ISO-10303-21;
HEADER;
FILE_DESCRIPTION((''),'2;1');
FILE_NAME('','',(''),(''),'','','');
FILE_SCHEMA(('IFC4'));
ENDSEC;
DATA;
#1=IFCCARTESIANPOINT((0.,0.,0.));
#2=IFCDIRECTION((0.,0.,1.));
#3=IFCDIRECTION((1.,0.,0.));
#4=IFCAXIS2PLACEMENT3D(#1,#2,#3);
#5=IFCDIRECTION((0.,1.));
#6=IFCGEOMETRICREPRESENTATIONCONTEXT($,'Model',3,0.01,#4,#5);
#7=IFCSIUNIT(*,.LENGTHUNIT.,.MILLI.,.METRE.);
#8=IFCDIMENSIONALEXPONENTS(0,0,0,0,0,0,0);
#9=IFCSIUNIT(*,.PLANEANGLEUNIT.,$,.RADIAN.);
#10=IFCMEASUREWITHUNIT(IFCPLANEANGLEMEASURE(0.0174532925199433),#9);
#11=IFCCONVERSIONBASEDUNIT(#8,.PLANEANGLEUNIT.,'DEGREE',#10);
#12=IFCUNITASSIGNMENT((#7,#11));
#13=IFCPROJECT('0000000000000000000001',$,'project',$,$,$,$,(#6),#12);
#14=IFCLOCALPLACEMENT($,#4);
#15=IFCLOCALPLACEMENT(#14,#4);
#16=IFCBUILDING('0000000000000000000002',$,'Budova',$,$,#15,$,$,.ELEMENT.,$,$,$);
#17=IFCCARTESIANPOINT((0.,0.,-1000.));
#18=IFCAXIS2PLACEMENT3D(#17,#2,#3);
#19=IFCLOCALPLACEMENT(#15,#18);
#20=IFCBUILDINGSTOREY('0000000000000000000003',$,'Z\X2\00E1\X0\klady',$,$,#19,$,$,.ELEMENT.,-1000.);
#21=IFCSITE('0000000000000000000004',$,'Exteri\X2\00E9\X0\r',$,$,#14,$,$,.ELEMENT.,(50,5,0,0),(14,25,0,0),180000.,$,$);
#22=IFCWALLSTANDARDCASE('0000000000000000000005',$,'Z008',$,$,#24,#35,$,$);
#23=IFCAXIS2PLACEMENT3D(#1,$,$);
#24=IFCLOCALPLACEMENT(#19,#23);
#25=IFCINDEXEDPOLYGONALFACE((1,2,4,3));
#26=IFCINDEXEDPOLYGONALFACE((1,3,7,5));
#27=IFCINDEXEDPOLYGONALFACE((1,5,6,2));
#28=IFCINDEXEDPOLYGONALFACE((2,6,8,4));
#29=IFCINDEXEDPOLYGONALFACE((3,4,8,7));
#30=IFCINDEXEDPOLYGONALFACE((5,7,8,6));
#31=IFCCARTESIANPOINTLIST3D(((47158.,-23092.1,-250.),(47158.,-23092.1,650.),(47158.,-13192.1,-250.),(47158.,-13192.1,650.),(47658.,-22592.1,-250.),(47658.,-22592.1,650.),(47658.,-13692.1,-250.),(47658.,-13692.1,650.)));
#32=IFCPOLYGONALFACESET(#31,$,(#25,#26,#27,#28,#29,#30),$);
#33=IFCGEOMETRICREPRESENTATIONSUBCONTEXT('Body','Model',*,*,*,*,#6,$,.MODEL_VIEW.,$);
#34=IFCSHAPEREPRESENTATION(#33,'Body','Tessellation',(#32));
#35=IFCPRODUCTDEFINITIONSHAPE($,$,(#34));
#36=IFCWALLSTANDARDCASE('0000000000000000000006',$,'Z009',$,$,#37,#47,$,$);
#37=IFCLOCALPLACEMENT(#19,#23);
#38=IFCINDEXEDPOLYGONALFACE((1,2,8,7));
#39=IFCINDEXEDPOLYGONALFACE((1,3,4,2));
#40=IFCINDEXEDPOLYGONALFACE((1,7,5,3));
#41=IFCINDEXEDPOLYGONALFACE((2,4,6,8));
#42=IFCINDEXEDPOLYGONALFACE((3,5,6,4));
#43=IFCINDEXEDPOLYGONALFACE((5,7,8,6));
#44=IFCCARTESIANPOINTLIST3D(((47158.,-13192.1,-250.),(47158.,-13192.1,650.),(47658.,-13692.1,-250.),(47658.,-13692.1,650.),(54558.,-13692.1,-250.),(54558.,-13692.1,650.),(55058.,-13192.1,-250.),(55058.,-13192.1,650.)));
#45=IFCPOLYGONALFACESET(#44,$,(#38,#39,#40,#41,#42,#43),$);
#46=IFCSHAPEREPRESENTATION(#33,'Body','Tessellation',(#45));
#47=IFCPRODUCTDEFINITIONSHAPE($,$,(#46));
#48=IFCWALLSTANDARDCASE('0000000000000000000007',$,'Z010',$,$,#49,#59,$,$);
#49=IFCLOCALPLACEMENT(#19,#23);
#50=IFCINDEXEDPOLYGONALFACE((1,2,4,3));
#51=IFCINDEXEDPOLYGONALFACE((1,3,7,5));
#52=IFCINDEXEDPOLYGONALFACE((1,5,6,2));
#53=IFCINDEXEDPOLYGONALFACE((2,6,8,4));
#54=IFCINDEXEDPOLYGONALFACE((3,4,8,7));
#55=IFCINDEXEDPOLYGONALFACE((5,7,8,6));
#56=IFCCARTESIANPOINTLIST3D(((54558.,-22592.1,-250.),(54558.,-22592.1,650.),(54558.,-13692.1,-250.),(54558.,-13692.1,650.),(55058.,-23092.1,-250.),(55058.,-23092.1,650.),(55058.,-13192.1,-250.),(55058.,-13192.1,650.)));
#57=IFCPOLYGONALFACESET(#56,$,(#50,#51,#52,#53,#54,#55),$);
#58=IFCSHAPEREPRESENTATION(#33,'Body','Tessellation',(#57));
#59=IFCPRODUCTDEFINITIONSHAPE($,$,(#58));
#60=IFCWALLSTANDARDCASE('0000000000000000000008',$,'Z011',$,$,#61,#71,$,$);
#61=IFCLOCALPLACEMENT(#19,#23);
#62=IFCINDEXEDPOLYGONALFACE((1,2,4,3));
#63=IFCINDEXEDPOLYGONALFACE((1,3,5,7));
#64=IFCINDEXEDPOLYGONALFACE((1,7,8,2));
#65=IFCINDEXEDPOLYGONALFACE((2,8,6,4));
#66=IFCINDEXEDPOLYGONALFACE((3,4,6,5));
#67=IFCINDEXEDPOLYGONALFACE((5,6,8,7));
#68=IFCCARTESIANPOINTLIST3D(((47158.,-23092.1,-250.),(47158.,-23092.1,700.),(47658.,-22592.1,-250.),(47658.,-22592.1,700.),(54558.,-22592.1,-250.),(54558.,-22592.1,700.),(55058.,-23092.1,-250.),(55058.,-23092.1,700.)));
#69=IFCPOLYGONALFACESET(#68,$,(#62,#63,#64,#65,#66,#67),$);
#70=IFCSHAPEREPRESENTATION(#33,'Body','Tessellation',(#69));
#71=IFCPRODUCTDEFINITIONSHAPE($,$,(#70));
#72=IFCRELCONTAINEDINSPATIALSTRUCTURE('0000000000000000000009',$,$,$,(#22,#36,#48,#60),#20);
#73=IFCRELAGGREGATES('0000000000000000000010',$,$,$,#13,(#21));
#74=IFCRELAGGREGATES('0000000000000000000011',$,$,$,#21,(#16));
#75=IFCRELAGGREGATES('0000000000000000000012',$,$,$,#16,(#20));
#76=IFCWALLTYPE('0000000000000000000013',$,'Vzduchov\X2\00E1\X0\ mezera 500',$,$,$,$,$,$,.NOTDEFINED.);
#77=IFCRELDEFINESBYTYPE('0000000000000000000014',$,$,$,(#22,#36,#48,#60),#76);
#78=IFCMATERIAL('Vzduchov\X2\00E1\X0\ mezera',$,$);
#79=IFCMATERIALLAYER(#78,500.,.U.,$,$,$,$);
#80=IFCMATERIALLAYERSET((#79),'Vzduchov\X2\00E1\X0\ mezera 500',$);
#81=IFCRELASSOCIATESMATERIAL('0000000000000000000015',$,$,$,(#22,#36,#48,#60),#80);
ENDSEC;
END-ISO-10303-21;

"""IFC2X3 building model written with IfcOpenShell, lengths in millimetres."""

from ifc_helpers import new_model, entity, si_unit, converted_unit, direction, frame, origin_with_axes, place, context, subcontext, project, spatial, polyline, outline, extrude, material, layer, layer_set, layer_usage, type_object, element, save


model = new_model("IFC2X3")

# Units and contexts
model_context = context("Model", 3, precision=0.01, world=origin_with_axes(), true_north=direction((0.0, 1.0)))
body_context = subcontext(model_context, "Body", "Model", "MODEL_VIEW")
ifc_project = project(units=[si_unit("LENGTHUNIT", "METRE", prefix="MILLI"), converted_unit("PLANEANGLEUNIT", "DEGREE", entity("IfcPlaneAngleMeasure", 0.0174532925199433), si_unit("PLANEANGLEUNIT", "RADIAN"), dimensions=[0, 0, 0, 0, 0, 0, 0])], contexts=[model_context])

# Site, building, storey
site_placement = place(None, origin_with_axes())
site = spatial("IfcSite", under=ifc_project, at=site_placement, Name="Exteriér", CompositionType="ELEMENT", RefLatitude=(50, 5, 0, 0), RefLongitude=(14, 25, 0, 0), RefElevation=180000.0)
building_placement = place(site_placement, origin_with_axes())
building = spatial("IfcBuilding", under=site, at=building_placement, Name="Budova", CompositionType="ELEMENT")
storey_placement = place(building_placement, frame((0.0, 0.0, -1000.0), z_axis=(0.0, 0.0, 1.0), x_axis=(1.0, 0.0, 0.0)))
storey = spatial("IfcBuildingStorey", under=building, at=storey_placement, Name="Základy", CompositionType="ELEMENT", Elevation=-1000.0)

# Walls
ifc_material = material(Name="Vzduchová mezera")
ifc_layer = layer(ifc_material, 500.0, ventilated="UNKNOWN")
ifc_layer_set = layer_set([ifc_layer], Name="Vzduchová mezera 500")
ifc_layer_usage_1 = layer_usage(ifc_layer_set, "AXIS2", "NEGATIVE", 0.0)
wall_type = type_object("IfcWallType", Name="Vzduchová mezera 500", PredefinedType="NOTDEFINED")
wall_1_placement = place(storey_placement, frame((47158.0, -23092.1, -250.0), z_axis=(0.0, 0.0, 1.0), x_axis=(0.0, 1.0, 0.0)))
element("IfcWallStandardCase", 1, at=wall_1_placement, inside=storey, type_object=wall_type, material=ifc_layer_usage_1, Name="Z008", context=body_context, shape_type="SweptSolid", body=[
    extrude(outline(polyline([(500.0, -500.0), (9400.0, -500.0), (9900.0, 0.0), (0.0, 0.0), (500.0, -500.0)])), origin_with_axes(), (0.0, 0.0, 1.0), 900.0),
])
ifc_layer_usage_2 = layer_usage(ifc_layer_set, "AXIS2", "NEGATIVE", 0.0)
wall_2_placement = place(storey_placement, frame((47158.0, -13192.1, -250.0), z_axis=(0.0, 0.0, 1.0), x_axis=(1.0, 0.0, 0.0)))
element("IfcWallStandardCase", 2, at=wall_2_placement, inside=storey, type_object=wall_type, material=ifc_layer_usage_2, Name="Z009", context=body_context, shape_type="SweptSolid", body=[
    extrude(outline(polyline([(500.0, -500.0), (7400.0, -500.0), (7900.0, 0.0), (0.0, 0.0), (500.0, -500.0)])), origin_with_axes(), (0.0, 0.0, 1.0), 900.0),
])
ifc_layer_usage_3 = layer_usage(ifc_layer_set, "AXIS2", "NEGATIVE", 0.0)
wall_3_placement = place(storey_placement, frame((55058.0, -13192.1, -250.0), z_axis=(0.0, 0.0, 1.0), x_axis=(0.0, -1.0, 0.0)))
element("IfcWallStandardCase", 3, at=wall_3_placement, inside=storey, type_object=wall_type, material=ifc_layer_usage_3, Name="Z010", context=body_context, shape_type="SweptSolid", body=[
    extrude(outline(polyline([(500.0, -500.0), (9400.0, -500.0), (9900.0, 0.0), (0.0, 0.0), (500.0, -500.0)])), origin_with_axes(), (0.0, 0.0, 1.0), 900.0),
])
ifc_layer_usage_4 = layer_usage(ifc_layer_set, "AXIS2", "NEGATIVE", 0.0)
wall_4_placement = place(storey_placement, frame((55058.0, -23092.1, -250.0), z_axis=(0.0, 0.0, 1.0), x_axis=(-1.0, 0.0, 0.0)))
element("IfcWallStandardCase", 4, at=wall_4_placement, inside=storey, type_object=wall_type, material=ifc_layer_usage_4, Name="Z011", context=body_context, shape_type="SweptSolid", body=[
    extrude(outline(polyline([(500.0, -500.0), (7400.0, -500.0), (7900.0, 0.0), (0.0, 0.0), (500.0, -500.0)])), origin_with_axes(), (0.0, 0.0, 1.0), 950.0),
])

save(model, "model.ifc")
